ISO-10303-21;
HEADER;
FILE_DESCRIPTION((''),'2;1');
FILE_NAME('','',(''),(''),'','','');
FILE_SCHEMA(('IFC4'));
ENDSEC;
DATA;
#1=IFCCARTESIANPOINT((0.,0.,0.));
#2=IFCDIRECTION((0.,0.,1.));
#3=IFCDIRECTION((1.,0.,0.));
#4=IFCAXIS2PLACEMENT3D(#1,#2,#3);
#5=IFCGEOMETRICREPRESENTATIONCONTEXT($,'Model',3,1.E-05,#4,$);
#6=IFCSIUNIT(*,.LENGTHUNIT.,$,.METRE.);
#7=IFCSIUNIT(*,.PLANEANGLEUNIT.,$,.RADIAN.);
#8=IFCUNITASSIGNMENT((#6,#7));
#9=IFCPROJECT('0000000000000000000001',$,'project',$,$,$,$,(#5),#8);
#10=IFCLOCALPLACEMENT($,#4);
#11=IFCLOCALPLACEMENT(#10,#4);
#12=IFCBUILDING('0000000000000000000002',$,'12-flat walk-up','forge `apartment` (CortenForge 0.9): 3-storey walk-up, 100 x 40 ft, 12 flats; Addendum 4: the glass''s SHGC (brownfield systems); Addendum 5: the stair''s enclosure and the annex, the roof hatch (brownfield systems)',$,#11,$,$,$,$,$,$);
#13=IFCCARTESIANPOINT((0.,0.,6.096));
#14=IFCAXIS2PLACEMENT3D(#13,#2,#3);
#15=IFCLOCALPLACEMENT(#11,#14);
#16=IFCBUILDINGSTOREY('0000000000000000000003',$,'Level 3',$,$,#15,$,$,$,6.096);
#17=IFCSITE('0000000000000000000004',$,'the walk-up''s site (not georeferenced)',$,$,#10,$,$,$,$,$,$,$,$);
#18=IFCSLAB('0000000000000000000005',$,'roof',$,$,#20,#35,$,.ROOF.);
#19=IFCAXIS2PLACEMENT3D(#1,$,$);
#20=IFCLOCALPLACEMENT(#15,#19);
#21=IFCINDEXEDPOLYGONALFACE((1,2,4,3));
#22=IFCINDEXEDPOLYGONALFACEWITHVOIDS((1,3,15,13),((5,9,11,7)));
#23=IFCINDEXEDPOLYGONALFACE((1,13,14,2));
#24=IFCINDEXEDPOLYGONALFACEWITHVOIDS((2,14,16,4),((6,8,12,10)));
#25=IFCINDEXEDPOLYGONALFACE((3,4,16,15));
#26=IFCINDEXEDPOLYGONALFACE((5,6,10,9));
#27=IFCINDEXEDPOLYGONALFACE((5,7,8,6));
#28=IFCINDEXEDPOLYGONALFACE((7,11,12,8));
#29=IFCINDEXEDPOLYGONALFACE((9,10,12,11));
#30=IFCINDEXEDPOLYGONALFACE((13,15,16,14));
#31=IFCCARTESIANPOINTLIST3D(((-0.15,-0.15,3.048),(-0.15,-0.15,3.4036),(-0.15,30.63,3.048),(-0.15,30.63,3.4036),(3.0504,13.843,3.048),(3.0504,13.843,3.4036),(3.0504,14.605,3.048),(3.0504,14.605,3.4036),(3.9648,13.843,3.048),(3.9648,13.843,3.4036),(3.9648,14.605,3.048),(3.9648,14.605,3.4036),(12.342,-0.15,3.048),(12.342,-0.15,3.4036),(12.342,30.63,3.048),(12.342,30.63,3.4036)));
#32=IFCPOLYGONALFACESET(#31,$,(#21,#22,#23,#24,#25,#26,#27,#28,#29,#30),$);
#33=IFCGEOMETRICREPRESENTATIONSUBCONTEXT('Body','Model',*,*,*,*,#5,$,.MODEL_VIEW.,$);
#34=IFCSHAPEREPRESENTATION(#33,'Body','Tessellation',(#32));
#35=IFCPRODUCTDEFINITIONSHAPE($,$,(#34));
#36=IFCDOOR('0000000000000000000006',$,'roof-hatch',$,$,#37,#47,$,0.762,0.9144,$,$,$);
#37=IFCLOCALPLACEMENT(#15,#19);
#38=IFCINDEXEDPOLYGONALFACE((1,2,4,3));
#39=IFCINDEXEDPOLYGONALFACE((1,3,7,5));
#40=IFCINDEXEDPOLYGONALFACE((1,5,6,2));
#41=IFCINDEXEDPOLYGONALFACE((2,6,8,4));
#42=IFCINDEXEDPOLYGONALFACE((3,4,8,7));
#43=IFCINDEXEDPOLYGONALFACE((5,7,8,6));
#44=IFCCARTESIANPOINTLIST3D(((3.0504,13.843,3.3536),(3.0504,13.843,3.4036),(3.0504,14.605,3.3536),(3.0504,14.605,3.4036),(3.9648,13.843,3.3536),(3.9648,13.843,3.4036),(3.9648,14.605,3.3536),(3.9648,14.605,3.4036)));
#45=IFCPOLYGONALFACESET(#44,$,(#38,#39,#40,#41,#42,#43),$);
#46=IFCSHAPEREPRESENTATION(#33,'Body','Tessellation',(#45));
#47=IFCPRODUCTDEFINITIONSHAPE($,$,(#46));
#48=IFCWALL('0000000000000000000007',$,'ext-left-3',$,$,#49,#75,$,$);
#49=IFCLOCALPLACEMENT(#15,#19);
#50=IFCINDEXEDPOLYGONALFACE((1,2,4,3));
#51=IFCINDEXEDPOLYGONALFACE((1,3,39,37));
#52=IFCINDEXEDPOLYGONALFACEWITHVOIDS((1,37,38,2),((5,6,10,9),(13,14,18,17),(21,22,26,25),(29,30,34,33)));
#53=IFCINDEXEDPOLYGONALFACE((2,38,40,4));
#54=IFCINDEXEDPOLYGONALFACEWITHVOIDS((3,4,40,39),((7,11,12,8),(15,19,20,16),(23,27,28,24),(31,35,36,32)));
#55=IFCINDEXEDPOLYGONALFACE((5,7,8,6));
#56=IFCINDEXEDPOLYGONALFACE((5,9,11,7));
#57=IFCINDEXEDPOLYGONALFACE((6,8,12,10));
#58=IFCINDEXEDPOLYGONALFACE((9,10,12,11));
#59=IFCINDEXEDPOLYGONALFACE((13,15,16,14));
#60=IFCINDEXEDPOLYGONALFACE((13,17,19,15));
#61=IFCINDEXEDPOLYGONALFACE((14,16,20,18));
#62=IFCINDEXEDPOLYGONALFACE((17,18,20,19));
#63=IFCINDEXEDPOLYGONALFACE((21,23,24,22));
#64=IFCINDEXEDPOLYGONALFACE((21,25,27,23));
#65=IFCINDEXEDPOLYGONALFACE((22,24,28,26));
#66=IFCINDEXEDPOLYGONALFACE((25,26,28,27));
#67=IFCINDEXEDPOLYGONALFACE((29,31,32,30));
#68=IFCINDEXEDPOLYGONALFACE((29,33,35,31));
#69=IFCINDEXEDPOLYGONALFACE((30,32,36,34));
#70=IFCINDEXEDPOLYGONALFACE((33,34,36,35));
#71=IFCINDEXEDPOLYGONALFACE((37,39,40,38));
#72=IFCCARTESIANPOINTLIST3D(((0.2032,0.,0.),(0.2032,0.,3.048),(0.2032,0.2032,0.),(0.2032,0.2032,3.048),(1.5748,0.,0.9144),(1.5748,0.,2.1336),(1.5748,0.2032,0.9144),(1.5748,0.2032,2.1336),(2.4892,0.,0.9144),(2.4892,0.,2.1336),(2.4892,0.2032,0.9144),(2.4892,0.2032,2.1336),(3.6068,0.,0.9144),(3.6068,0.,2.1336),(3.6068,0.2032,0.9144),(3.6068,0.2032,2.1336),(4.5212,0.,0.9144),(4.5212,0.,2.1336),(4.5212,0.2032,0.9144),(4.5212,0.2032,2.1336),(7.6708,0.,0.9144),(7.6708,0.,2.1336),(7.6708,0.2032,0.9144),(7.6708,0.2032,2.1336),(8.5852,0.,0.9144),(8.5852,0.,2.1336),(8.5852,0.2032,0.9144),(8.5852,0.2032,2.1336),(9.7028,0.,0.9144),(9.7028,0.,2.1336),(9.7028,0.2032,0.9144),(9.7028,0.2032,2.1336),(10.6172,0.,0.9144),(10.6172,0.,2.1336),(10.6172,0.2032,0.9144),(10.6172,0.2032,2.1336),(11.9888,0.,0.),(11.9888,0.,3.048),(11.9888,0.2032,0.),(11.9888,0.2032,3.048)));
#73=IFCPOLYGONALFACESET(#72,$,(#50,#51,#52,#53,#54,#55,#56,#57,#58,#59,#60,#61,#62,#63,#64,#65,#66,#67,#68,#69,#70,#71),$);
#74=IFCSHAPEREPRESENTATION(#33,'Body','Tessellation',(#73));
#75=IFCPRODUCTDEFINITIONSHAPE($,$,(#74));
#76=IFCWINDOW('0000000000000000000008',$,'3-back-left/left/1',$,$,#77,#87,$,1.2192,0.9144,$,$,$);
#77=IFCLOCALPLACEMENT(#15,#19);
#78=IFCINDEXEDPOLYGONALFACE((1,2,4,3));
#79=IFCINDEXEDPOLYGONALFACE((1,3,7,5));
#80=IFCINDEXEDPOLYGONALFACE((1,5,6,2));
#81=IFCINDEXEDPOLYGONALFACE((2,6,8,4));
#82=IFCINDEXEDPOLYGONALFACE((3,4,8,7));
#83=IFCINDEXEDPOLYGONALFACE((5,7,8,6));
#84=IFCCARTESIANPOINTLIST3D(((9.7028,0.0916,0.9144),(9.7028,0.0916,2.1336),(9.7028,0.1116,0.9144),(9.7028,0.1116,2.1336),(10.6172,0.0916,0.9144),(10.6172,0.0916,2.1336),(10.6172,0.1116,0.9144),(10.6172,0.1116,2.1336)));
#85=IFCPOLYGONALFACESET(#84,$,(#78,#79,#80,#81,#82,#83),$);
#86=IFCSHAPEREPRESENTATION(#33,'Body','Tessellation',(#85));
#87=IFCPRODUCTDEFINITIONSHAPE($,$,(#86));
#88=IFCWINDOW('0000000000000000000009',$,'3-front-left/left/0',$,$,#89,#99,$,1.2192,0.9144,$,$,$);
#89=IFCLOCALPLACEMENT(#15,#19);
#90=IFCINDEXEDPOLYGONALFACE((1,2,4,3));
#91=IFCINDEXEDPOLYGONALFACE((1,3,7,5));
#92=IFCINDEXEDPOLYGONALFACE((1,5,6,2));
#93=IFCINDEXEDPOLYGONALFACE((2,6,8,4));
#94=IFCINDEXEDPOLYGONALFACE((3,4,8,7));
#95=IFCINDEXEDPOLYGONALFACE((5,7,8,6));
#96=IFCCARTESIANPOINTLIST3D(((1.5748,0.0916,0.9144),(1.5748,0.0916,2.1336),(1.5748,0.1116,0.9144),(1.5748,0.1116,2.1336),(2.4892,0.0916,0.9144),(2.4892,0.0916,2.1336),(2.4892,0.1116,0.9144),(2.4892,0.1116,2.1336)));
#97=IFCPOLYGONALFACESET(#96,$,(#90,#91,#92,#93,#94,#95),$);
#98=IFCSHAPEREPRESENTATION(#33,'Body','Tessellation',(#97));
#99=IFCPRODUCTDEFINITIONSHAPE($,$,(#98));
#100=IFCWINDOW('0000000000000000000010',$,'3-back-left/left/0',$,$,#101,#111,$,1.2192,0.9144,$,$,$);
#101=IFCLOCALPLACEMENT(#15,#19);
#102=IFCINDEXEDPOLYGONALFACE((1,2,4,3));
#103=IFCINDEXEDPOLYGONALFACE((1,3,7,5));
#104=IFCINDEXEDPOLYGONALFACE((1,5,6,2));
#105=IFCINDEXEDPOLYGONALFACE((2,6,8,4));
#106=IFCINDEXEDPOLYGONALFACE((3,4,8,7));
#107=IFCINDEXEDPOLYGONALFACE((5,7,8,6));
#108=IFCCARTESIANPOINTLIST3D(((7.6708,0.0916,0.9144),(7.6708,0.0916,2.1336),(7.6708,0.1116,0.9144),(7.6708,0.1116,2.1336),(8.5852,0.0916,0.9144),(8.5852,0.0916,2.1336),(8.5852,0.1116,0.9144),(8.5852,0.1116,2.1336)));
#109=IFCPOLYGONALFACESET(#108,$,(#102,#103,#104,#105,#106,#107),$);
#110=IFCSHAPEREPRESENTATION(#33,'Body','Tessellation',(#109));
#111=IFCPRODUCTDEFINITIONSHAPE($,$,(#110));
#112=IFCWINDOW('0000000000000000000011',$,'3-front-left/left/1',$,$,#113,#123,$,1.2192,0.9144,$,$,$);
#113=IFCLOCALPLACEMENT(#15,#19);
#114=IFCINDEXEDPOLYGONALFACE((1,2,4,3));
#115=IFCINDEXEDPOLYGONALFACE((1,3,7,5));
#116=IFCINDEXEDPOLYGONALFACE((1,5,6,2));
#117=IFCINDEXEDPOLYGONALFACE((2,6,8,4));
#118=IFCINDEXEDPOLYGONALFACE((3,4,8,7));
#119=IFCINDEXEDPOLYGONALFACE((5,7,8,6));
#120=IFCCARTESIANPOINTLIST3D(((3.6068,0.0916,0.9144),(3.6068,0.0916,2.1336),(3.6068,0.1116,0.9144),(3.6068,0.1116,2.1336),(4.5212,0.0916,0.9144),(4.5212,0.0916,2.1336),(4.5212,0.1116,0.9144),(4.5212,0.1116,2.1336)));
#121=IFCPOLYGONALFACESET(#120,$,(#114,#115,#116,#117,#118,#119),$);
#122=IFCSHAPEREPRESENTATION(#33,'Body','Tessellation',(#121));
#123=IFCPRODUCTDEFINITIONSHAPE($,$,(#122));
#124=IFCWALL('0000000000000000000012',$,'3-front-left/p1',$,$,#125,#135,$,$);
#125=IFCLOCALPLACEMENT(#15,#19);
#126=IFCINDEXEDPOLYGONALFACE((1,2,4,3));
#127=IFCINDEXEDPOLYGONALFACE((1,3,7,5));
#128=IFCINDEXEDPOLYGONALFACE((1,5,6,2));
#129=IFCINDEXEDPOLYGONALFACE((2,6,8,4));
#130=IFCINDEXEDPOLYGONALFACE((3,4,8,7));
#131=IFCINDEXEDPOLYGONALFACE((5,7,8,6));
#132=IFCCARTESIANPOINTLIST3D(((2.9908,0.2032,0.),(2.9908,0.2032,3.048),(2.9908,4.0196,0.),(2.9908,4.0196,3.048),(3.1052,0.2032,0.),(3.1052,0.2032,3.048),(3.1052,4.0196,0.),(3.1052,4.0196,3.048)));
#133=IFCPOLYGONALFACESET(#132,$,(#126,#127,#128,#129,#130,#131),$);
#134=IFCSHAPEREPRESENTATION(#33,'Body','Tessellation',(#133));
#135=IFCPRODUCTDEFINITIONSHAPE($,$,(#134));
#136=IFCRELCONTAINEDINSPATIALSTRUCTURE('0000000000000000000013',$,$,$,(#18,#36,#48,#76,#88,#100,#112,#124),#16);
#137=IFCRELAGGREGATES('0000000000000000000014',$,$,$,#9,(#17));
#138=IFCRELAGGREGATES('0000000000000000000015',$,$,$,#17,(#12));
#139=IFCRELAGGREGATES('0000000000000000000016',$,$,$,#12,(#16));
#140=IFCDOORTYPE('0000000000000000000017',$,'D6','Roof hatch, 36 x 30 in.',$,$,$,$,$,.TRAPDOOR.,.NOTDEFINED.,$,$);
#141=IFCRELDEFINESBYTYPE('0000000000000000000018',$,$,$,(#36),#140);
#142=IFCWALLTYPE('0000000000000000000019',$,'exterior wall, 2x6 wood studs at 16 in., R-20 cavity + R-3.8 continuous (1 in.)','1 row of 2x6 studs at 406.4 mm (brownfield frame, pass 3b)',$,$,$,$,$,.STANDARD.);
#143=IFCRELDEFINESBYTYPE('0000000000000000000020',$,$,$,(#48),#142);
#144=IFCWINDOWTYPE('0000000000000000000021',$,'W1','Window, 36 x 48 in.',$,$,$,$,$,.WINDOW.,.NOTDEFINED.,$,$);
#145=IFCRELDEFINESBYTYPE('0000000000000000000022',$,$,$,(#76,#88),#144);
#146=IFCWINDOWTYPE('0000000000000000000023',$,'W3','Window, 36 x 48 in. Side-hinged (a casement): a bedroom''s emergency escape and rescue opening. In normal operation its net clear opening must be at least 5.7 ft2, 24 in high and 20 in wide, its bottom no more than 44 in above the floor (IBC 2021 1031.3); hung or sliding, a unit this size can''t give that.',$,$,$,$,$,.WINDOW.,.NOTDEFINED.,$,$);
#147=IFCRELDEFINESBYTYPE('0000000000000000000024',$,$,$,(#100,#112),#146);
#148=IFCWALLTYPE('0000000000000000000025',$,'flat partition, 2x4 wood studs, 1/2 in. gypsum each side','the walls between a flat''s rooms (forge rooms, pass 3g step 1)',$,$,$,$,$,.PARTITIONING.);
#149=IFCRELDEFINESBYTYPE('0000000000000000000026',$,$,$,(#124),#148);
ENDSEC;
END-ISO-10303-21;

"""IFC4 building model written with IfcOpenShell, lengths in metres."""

from ifc_helpers import new_model, si_unit, frame, frame_2d, origin, origin_with_axes, place, context, subcontext, project, spatial, rectangle, extrude, type_object, element, fill, save


model = new_model("IFC4")

# Units and contexts
model_context = context("Model", 3, precision=1e-05, world=origin_with_axes())
body_context = subcontext(model_context, "Body", "Model", "MODEL_VIEW")
ifc_project = project(units=[si_unit("LENGTHUNIT", "METRE"), si_unit("PLANEANGLEUNIT", "RADIAN")], contexts=[model_context])

# Site, building, storey
site_placement = place(None, origin_with_axes())
site = spatial("IfcSite", under=ifc_project, at=site_placement, Name="the walk-up's site (not georeferenced)")
building_placement = place(site_placement, origin_with_axes())
building = spatial("IfcBuilding", under=site, at=building_placement, Name="12-flat walk-up", Description="forge `apartment` (CortenForge 0.9): 3-storey walk-up, 100 x 40 ft, 12 flats; Addendum 4: the glass's SHGC (brownfield systems); Addendum 5: the stair's enclosure and the annex, the roof hatch (brownfield systems)")
storey_placement = place(building_placement, frame((0.0, 0.0, 6.096), z_axis=(0.0, 0.0, 1.0), x_axis=(1.0, 0.0, 0.0)))
storey = spatial("IfcBuildingStorey", under=building, at=storey_placement, Name="Level 3", Elevation=6.096)

# Slab, opening, door
slab_placement = place(storey_placement, frame((-0.15, -0.15, 3.048), z_axis=(0.0, 0.0, 1.0), x_axis=(1.0, 0.0, 0.0)))
slab = element("IfcSlab", 1, at=slab_placement, inside=storey, Name="roof", PredefinedType="ROOF", context=body_context, shape_type="SweptSolid", body=[
    extrude(rectangle(XDim=12.492, YDim=30.78, at=frame_2d((6.246, 15.39))), origin(), (0.0, 0.0, 1.0), 0.3556),
])
opening_1_placement = place(slab_placement, frame((3.2004, 13.993, 0.0), z_axis=(0.0, 0.0, 1.0), x_axis=(1.0, 0.0, 0.0)))
opening_1 = element("IfcOpeningElement", 2, at=opening_1_placement, cuts=slab, PredefinedType="OPENING", context=body_context, shape_type="SweptSolid", body=[
    extrude(rectangle(XDim=0.9144, YDim=0.762, at=frame_2d((0.4572, 0.381))), origin(), (0.0, 0.0, 1.0), 0.3556),
])
door_type = type_object("IfcDoorType", Name="D6", Description="Roof hatch, 36 x 30 in.", OperationType="NOTDEFINED", PredefinedType="TRAPDOOR")
door_placement = place(opening_1_placement, frame((0.0, 0.0, 0.3056), z_axis=(0.0, 0.0, 1.0), x_axis=(1.0, 0.0, 0.0)))
door = element("IfcDoor", 3, at=door_placement, inside=storey, type_object=door_type, Name="roof-hatch", OverallHeight=0.762, OverallWidth=0.9144, context=body_context, shape_type="SweptSolid", body=[
    extrude(rectangle(XDim=0.9144, YDim=0.762, at=frame_2d((0.4572, 0.381))), origin(), (0.0, 0.0, 1.0), 0.05),
])
fill(opening_1, door)

# Wall, openings, windows
wall_type_1 = type_object("IfcWallType", Name="exterior wall, 2x6 wood studs at 16 in., R-20 cavity + R-3.8 continuous (1 in.)", Description="1 row of 2x6 studs at 406.4 mm (brownfield frame, pass 3b)", PredefinedType="STANDARD")
wall_1_placement = place(storey_placement, frame((0.2032, 0.0, 0.0), z_axis=(0.0, 0.0, 1.0), x_axis=(1.0, 0.0, 0.0)))
wall_1 = element("IfcWall", 4, at=wall_1_placement, inside=storey, type_object=wall_type_1, Name="ext-left-3", context=body_context, shape_type="SweptSolid", body=[
    extrude(rectangle(XDim=11.7856, YDim=0.2032, at=frame_2d((5.8928, 0.1016))), origin(), (0.0, 0.0, 1.0), 3.048),
])
opening_2_placement = place(wall_1_placement, frame((7.4676, 0.0, 0.9144), z_axis=(0.0, 0.0, 1.0), x_axis=(1.0, 0.0, 0.0)))
opening_2 = element("IfcOpeningElement", 5, at=opening_2_placement, cuts=wall_1, PredefinedType="OPENING", context=body_context, shape_type="SweptSolid", body=[
    extrude(rectangle(XDim=0.9144, YDim=0.2032, at=frame_2d((0.4572, 0.1016))), origin(), (0.0, 0.0, 1.0), 1.2192),
])
opening_3_placement = place(wall_1_placement, frame((9.4996, 0.0, 0.9144), z_axis=(0.0, 0.0, 1.0), x_axis=(1.0, 0.0, 0.0)))
opening_3 = element("IfcOpeningElement", 6, at=opening_3_placement, cuts=wall_1, PredefinedType="OPENING", context=body_context, shape_type="SweptSolid", body=[
    extrude(rectangle(XDim=0.9144, YDim=0.2032, at=frame_2d((0.4572, 0.1016))), origin(), (0.0, 0.0, 1.0), 1.2192),
])
opening_4_placement = place(wall_1_placement, frame((1.3716, 0.0, 0.9144), z_axis=(0.0, 0.0, 1.0), x_axis=(1.0, 0.0, 0.0)))
opening_4 = element("IfcOpeningElement", 7, at=opening_4_placement, cuts=wall_1, PredefinedType="OPENING", context=body_context, shape_type="SweptSolid", body=[
    extrude(rectangle(XDim=0.9144, YDim=0.2032, at=frame_2d((0.4572, 0.1016))), origin(), (0.0, 0.0, 1.0), 1.2192),
])
opening_5_placement = place(wall_1_placement, frame((3.4036, 0.0, 0.9144), z_axis=(0.0, 0.0, 1.0), x_axis=(1.0, 0.0, 0.0)))
opening_5 = element("IfcOpeningElement", 8, at=opening_5_placement, cuts=wall_1, PredefinedType="OPENING", context=body_context, shape_type="SweptSolid", body=[
    extrude(rectangle(XDim=0.9144, YDim=0.2032, at=frame_2d((0.4572, 0.1016))), origin(), (0.0, 0.0, 1.0), 1.2192),
])
window_type_1 = type_object("IfcWindowType", Name="W1", Description="Window, 36 x 48 in.", PartitioningType="NOTDEFINED", PredefinedType="WINDOW")
window_1_placement = place(opening_3_placement, frame((0.0, 0.0916, 0.0), z_axis=(0.0, 0.0, 1.0), x_axis=(1.0, 0.0, 0.0)))
window_1 = element("IfcWindow", 9, at=window_1_placement, inside=storey, type_object=window_type_1, Name="3-back-left/left/1", OverallHeight=1.2192, OverallWidth=0.9144, context=body_context, shape_type="SweptSolid", body=[
    extrude(rectangle(XDim=0.9144, YDim=0.02, at=frame_2d((0.4572, 0.01))), origin(), (0.0, 0.0, 1.0), 1.2192),
])
fill(opening_3, window_1)
window_2_placement = place(opening_4_placement, frame((0.0, 0.0916, 0.0), z_axis=(0.0, 0.0, 1.0), x_axis=(1.0, 0.0, 0.0)))
window_2 = element("IfcWindow", 10, at=window_2_placement, inside=storey, type_object=window_type_1, Name="3-front-left/left/0", OverallHeight=1.2192, OverallWidth=0.9144, context=body_context, shape_type="SweptSolid", body=[
    extrude(rectangle(XDim=0.9144, YDim=0.02, at=frame_2d((0.4572, 0.01))), origin(), (0.0, 0.0, 1.0), 1.2192),
])
fill(opening_4, window_2)
window_type_2 = type_object("IfcWindowType", Name="W3", Description="Window, 36 x 48 in. Side-hinged (a casement): a bedroom's emergency escape and rescue opening. In normal operation its net clear opening must be at least 5.7 ft2, 24 in high and 20 in wide, its bottom no more than 44 in above the floor (IBC 2021 1031.3); hung or sliding, a unit this size can't give that.", PartitioningType="NOTDEFINED", PredefinedType="WINDOW")
window_3_placement = place(opening_2_placement, frame((0.0, 0.0916, 0.0), z_axis=(0.0, 0.0, 1.0), x_axis=(1.0, 0.0, 0.0)))
window_3 = element("IfcWindow", 11, at=window_3_placement, inside=storey, type_object=window_type_2, Name="3-back-left/left/0", OverallHeight=1.2192, OverallWidth=0.9144, context=body_context, shape_type="SweptSolid", body=[
    extrude(rectangle(XDim=0.9144, YDim=0.02, at=frame_2d((0.4572, 0.01))), origin(), (0.0, 0.0, 1.0), 1.2192),
])
fill(opening_2, window_3)
window_4_placement = place(opening_5_placement, frame((0.0, 0.0916, 0.0), z_axis=(0.0, 0.0, 1.0), x_axis=(1.0, 0.0, 0.0)))
window_4 = element("IfcWindow", 12, at=window_4_placement, inside=storey, type_object=window_type_2, Name="3-front-left/left/1", OverallHeight=1.2192, OverallWidth=0.9144, context=body_context, shape_type="SweptSolid", body=[
    extrude(rectangle(XDim=0.9144, YDim=0.02, at=frame_2d((0.4572, 0.01))), origin(), (0.0, 0.0, 1.0), 1.2192),
])
fill(opening_5, window_4)

# Wall
wall_type_2 = type_object("IfcWallType", Name="flat partition, 2x4 wood studs, 1/2 in. gypsum each side", Description="the walls between a flat's rooms (forge rooms, pass 3g step 1)", PredefinedType="PARTITIONING")
wall_2_placement = place(storey_placement, frame((2.9909, 0.2032, 0.0), z_axis=(0.0, 0.0, 1.0), x_axis=(1.0, 0.0, 0.0)))
element("IfcWall", 13, at=wall_2_placement, inside=storey, type_object=wall_type_2, Name="3-front-left/p1", context=body_context, shape_type="SweptSolid", body=[
    extrude(rectangle(XDim=0.1143, YDim=3.8163, at=frame_2d((0.0572, 1.9082))), origin(), (0.0, 0.0, 1.0), 3.048),
])

save(model, "model.ifc")
